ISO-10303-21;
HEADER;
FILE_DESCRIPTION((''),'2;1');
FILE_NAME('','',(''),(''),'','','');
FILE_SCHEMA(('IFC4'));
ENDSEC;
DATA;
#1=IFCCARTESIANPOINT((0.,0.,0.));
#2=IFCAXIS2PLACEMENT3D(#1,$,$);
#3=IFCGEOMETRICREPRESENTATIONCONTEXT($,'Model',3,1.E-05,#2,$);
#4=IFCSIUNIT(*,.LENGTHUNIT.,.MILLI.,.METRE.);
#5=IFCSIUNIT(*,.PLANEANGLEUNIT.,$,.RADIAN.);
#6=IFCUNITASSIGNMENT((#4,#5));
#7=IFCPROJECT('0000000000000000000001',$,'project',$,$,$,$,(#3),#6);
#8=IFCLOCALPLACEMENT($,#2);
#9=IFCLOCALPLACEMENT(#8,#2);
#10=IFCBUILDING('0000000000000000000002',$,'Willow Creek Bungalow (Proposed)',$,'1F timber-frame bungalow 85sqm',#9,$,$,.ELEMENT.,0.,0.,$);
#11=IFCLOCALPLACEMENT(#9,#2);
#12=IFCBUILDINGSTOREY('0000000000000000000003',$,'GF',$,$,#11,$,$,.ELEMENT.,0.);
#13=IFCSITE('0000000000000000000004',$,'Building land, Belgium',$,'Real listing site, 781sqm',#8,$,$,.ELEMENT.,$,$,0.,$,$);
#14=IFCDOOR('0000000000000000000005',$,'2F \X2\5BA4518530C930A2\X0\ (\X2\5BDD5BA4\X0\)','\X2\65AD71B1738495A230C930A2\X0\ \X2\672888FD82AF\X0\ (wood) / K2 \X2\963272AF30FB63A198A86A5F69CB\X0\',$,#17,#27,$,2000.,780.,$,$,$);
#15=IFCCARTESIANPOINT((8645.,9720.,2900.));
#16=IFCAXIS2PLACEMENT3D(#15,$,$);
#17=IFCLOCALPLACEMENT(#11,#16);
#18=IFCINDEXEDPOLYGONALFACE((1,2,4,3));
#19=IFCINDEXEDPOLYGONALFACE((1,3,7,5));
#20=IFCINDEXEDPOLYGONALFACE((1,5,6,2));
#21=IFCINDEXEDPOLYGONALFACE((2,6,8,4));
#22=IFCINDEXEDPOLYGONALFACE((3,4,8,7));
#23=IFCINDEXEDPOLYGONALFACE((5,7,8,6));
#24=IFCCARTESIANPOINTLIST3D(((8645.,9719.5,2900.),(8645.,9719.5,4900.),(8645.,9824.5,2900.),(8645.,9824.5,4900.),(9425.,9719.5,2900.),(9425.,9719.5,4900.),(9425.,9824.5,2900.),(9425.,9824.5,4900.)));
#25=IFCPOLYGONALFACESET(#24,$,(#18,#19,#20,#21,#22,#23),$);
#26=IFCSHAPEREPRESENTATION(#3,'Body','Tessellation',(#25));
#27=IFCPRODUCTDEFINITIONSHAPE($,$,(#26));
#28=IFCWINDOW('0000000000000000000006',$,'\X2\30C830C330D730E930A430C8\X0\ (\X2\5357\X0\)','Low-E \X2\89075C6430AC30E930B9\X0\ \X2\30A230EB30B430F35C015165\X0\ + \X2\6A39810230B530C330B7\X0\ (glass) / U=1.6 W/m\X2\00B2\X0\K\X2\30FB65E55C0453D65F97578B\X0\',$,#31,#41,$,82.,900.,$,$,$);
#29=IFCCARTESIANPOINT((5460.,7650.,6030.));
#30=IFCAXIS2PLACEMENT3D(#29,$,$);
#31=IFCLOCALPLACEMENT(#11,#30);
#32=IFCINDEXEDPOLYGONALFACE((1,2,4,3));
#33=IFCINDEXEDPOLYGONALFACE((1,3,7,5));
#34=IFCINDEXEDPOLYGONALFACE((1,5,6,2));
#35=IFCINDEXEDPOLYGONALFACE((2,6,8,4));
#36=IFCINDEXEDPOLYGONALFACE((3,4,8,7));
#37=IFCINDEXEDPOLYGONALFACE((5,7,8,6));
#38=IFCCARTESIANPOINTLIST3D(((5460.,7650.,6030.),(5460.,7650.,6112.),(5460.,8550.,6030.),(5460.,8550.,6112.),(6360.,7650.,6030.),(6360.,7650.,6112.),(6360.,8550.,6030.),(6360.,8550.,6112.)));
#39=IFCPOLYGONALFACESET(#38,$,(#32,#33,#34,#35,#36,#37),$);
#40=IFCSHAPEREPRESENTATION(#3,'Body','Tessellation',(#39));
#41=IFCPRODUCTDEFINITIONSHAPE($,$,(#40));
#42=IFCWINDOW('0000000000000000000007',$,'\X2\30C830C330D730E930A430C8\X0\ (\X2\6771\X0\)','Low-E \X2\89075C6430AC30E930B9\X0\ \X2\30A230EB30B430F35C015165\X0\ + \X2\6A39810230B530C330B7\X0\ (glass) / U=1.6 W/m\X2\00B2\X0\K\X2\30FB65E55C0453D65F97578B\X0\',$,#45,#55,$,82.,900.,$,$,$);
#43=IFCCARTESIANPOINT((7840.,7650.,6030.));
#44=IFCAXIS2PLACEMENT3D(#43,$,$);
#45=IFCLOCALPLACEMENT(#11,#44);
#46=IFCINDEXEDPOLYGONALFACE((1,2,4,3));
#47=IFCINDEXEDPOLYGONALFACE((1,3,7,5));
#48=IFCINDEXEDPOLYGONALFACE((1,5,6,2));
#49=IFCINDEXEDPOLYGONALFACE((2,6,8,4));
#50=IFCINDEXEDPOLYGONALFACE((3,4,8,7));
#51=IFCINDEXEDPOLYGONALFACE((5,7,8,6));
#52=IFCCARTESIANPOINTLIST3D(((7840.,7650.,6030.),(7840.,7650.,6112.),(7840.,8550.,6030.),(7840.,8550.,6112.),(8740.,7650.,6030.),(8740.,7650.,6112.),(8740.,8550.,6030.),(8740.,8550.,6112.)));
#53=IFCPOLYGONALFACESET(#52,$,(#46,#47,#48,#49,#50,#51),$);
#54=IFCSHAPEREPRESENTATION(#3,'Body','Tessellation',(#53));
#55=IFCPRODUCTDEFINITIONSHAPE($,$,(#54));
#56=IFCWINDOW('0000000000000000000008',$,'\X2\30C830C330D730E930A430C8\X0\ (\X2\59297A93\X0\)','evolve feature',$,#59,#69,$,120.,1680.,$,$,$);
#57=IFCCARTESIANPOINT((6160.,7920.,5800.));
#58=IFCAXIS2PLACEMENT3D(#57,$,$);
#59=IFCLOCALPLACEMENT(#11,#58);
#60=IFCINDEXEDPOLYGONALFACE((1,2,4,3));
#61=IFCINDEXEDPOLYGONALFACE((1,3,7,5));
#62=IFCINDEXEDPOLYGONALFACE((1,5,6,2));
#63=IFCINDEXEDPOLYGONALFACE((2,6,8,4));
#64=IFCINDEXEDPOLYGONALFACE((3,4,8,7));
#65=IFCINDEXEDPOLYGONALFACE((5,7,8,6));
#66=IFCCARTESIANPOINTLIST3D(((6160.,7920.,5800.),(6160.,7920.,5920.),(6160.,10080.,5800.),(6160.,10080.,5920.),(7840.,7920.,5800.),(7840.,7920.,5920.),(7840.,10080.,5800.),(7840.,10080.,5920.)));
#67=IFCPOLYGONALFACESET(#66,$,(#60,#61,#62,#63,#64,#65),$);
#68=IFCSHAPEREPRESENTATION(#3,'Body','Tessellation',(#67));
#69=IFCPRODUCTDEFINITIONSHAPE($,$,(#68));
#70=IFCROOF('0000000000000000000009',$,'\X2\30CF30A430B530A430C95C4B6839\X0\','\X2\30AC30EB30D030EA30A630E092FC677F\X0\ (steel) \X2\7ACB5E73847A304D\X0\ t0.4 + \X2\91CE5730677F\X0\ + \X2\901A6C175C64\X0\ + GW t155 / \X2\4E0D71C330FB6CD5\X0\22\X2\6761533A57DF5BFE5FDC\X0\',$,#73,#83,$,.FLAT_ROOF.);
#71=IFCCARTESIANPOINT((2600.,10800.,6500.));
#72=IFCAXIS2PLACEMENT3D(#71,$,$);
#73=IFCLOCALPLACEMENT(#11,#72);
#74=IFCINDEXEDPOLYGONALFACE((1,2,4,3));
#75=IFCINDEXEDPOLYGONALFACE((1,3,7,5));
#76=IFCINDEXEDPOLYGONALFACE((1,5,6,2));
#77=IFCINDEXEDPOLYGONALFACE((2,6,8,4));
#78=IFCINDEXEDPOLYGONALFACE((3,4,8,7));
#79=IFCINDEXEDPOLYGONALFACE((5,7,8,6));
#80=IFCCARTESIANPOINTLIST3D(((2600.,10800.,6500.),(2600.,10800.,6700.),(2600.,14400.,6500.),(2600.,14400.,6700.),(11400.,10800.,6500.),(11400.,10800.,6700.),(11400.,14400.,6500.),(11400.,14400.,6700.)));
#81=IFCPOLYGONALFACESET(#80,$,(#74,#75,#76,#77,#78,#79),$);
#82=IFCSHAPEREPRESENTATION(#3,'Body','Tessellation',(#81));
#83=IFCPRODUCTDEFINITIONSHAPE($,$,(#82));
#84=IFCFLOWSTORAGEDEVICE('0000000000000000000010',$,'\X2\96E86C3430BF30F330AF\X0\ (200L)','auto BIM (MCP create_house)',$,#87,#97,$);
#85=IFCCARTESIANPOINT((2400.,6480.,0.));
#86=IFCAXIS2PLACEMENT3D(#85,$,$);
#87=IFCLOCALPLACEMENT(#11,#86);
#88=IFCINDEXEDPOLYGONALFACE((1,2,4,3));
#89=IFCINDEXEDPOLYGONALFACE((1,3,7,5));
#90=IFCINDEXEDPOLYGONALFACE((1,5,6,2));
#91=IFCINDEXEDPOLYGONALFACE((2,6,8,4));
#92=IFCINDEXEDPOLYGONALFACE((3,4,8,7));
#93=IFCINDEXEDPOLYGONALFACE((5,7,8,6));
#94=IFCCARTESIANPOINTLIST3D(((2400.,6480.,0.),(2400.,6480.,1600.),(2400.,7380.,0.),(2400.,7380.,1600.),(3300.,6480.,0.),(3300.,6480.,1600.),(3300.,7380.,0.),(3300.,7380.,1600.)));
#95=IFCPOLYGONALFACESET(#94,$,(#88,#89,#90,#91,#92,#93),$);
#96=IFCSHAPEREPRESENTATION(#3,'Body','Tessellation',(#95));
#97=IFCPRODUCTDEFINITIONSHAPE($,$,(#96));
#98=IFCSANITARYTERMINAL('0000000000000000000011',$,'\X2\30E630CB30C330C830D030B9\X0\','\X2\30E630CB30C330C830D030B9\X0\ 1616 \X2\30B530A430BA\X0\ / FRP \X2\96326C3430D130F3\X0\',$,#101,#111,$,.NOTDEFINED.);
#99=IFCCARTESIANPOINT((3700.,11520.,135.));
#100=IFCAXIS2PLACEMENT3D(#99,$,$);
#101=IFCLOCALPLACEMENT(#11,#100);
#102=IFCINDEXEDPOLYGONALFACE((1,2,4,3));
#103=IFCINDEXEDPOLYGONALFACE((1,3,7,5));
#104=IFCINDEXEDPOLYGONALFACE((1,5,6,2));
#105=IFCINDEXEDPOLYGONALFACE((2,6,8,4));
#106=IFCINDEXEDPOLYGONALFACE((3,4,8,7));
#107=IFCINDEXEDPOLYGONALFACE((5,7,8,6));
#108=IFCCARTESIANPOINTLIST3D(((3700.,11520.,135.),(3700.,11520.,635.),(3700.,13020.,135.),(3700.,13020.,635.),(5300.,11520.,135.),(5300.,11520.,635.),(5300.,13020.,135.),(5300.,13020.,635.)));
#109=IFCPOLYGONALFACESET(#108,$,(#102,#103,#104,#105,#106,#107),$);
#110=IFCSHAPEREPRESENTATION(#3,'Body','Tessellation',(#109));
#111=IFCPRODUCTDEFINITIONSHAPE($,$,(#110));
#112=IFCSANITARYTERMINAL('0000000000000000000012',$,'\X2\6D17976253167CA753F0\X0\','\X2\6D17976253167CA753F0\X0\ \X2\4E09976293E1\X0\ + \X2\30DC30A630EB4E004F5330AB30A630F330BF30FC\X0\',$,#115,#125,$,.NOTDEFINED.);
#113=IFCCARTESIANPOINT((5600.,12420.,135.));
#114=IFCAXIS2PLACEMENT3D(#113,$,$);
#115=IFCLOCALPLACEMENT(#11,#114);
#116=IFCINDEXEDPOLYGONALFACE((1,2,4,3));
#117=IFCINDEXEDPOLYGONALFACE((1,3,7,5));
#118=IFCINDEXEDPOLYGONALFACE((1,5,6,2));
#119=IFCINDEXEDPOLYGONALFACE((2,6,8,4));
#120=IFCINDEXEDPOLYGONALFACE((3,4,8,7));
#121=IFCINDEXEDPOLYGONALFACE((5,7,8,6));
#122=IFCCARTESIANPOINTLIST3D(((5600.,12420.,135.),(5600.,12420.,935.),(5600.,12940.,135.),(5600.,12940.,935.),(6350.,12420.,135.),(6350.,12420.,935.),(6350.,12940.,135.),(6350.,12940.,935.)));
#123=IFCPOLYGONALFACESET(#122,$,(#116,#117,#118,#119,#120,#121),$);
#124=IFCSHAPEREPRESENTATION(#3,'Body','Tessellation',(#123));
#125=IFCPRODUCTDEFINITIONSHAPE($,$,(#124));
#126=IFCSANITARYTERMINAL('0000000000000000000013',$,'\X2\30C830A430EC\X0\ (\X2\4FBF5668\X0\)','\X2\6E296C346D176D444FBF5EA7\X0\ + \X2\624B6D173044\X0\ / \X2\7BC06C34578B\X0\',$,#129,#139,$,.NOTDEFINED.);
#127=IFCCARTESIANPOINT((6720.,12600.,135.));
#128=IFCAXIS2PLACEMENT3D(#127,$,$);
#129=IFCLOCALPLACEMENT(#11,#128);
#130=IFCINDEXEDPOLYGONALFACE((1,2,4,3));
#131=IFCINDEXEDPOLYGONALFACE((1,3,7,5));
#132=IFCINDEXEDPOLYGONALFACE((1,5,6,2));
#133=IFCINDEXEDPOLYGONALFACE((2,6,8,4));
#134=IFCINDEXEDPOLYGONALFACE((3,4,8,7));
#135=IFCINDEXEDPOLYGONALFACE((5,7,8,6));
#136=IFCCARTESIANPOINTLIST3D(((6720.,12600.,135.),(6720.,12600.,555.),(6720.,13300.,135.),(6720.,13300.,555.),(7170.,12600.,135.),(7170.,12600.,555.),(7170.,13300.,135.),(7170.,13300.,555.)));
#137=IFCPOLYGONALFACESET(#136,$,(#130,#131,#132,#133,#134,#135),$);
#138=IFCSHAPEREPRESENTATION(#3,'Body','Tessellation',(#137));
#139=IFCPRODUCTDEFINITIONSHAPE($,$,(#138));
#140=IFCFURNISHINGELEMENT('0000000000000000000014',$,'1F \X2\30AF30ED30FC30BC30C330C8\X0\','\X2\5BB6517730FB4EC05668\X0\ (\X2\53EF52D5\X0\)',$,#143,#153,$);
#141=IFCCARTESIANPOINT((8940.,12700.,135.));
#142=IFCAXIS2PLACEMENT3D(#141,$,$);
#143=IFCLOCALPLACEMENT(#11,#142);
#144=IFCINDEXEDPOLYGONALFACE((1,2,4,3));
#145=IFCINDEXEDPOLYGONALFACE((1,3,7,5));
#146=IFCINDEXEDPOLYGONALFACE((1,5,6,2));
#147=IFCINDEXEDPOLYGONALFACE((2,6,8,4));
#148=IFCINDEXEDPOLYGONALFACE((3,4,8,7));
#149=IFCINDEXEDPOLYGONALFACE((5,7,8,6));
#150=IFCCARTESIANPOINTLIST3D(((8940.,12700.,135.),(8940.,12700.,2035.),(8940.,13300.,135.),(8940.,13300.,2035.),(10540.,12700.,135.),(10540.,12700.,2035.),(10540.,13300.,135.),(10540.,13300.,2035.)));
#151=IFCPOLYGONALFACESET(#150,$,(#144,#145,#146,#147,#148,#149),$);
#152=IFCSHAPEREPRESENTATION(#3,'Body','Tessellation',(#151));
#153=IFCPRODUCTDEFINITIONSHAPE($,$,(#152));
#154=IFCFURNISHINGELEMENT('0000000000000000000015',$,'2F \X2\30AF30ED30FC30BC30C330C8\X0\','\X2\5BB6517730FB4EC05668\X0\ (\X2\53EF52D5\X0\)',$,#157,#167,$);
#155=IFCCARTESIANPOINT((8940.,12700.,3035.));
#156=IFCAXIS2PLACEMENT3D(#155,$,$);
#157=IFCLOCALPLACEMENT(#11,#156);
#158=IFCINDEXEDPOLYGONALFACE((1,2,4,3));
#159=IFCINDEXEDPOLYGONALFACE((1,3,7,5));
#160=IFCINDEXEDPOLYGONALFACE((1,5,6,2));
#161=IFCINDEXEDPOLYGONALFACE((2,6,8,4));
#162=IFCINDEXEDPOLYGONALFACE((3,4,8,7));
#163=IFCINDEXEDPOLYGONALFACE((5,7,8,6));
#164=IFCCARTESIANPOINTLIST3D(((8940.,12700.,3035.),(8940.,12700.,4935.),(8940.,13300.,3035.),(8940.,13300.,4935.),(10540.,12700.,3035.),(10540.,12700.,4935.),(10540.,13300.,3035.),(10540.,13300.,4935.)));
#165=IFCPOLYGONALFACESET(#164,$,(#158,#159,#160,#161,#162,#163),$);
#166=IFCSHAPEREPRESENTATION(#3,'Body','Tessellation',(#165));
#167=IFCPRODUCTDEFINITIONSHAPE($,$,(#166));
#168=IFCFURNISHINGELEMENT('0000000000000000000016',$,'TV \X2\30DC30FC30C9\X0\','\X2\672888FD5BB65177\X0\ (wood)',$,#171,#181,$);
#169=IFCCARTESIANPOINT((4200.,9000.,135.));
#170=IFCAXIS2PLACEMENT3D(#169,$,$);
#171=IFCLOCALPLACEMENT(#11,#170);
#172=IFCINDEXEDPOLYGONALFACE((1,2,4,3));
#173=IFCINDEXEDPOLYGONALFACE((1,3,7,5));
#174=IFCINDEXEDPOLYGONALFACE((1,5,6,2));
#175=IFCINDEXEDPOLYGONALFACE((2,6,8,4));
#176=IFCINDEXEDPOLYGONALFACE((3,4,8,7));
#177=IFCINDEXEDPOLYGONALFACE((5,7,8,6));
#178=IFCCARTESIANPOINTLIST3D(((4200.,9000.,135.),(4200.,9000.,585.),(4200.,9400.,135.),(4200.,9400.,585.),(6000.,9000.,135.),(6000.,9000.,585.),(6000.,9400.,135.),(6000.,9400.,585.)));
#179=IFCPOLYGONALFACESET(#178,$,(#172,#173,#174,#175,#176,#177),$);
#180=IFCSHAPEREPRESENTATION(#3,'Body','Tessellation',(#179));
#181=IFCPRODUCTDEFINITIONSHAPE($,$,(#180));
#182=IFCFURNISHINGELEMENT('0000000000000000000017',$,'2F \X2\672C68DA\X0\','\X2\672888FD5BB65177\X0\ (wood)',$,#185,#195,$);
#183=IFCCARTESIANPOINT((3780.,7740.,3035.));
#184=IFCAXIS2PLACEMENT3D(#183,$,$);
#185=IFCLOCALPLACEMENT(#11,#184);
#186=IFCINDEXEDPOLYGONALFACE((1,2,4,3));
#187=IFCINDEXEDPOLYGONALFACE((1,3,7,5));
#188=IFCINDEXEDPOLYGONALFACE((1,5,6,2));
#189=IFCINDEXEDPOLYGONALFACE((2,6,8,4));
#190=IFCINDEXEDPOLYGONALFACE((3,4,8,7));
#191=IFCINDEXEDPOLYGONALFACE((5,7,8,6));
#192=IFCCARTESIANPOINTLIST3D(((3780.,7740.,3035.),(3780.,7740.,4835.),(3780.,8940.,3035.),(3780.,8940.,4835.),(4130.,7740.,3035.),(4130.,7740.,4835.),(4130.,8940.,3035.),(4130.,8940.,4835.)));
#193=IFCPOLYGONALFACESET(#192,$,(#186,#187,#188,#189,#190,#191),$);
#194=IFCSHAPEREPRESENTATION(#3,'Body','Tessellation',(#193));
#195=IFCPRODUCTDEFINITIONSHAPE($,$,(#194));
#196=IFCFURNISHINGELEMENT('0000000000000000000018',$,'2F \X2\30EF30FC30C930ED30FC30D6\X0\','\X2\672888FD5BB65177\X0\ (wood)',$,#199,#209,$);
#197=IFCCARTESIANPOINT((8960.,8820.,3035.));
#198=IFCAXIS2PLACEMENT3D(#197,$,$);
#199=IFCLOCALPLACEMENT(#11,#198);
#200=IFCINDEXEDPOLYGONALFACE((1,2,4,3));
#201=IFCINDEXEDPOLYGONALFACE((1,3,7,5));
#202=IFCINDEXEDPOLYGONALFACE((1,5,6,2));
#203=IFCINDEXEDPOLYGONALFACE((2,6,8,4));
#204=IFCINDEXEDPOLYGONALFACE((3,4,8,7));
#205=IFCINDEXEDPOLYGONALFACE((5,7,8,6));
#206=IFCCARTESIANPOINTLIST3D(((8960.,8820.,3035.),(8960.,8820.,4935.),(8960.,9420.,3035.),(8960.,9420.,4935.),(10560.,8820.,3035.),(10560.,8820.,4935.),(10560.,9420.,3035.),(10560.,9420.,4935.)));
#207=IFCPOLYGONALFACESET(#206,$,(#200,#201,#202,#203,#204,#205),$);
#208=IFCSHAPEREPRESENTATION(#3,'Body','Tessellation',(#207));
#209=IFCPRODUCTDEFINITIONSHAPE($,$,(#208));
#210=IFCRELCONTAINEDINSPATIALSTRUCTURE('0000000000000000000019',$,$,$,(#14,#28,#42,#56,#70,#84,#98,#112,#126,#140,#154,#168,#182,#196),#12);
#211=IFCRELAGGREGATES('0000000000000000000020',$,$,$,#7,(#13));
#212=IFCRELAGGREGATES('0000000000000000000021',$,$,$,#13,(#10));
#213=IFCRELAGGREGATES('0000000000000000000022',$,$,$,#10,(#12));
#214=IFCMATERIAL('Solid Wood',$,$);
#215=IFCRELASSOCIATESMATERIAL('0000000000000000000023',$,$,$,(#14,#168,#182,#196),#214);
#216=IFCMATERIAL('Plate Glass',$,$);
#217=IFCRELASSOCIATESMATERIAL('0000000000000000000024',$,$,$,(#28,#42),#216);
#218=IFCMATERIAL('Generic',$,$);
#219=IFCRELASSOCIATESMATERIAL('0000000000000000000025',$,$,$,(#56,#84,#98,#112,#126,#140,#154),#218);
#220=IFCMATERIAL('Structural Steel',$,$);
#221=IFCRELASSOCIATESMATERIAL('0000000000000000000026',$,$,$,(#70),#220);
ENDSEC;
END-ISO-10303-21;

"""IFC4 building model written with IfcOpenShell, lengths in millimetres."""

from ifc_helpers import new_model, si_unit, frame, frame_2d, origin, place, context, project, spatial, rectangle, extrude, material, element, save


model = new_model("IFC4")

# Units and contexts
model_context = context("Model", 3, precision=1e-05, world=origin())
ifc_project = project(units=[si_unit("LENGTHUNIT", "METRE", prefix="MILLI"), si_unit("PLANEANGLEUNIT", "RADIAN")], contexts=[model_context])

# Site, building, storey
site_placement = place(None, origin())
site = spatial("IfcSite", under=ifc_project, at=site_placement, Name="Building land, Belgium", ObjectType="Real listing site, 781sqm", CompositionType="ELEMENT", RefElevation=0.0)
building_placement = place(site_placement, origin())
building = spatial("IfcBuilding", under=site, at=building_placement, Name="Willow Creek Bungalow (Proposed)", ObjectType="1F timber-frame bungalow 85sqm", CompositionType="ELEMENT", ElevationOfRefHeight=0.0, ElevationOfTerrain=0.0)
storey_placement = place(building_placement, origin())
storey = spatial("IfcBuildingStorey", under=building, at=storey_placement, Name="GF", CompositionType="ELEMENT", Elevation=0.0)

# Shared definitions
ifc_material_1 = material(Name="Solid Wood")
ifc_material_2 = material(Name="Plate Glass")

# Door
door_1_placement = place(storey_placement, frame((8645.0, 9720.0, 2900.0)))
element("IfcDoor", 1, at=door_1_placement, inside=storey, material=ifc_material_1, Name="2F 室内ドア (寝室)", Description="断熱玄関ドア 木製芯 (wood) / K2 防犯・採風機構", OverallHeight=2000.0, OverallWidth=780.0, context=model_context, shape_type="SweptSolid", body=[
    extrude(rectangle(XDim=780.0, YDim=105.0, at=frame_2d((390.0, 52.0))), frame((8645.0, 9720.0, 2900.0)), (0.0, 0.0, 1.0), 2000.0),
])

# Windows
window_1_placement = place(storey_placement, frame((5460.0, 7650.0, 6030.0)))
element("IfcWindow", 2, at=window_1_placement, inside=storey, material=ifc_material_2, Name="トップライト (南)", Description="Low-E 複層ガラス アルゴン封入 + 樹脂サッシ (glass) / U=1.6 W/m²K・日射取得型", OverallHeight=82.0, OverallWidth=900.0, context=model_context, shape_type="SweptSolid", body=[
    extrude(rectangle(XDim=900.0, YDim=900.0, at=frame_2d((450.0, 450.0))), frame((5460.0, 7650.0, 6030.0)), (0.0, 0.0, 1.0), 82.0),
])
window_2_placement = place(storey_placement, frame((7840.0, 7650.0, 6030.0)))
element("IfcWindow", 3, at=window_2_placement, inside=storey, material=ifc_material_2, Name="トップライト (東)", Description="Low-E 複層ガラス アルゴン封入 + 樹脂サッシ (glass) / U=1.6 W/m²K・日射取得型", OverallHeight=82.0, OverallWidth=900.0, context=model_context, shape_type="SweptSolid", body=[
    extrude(rectangle(XDim=900.0, YDim=900.0, at=frame_2d((450.0, 450.0))), frame((7840.0, 7650.0, 6030.0)), (0.0, 0.0, 1.0), 82.0),
])
ifc_material_3 = material(Name="Generic")
window_3_placement = place(storey_placement, frame((6160.0, 7920.0, 5800.0)))
element("IfcWindow", 4, at=window_3_placement, inside=storey, material=ifc_material_3, Name="トップライト (天窓)", Description="evolve feature", OverallHeight=120.0, OverallWidth=1680.0, context=model_context, shape_type="SweptSolid", body=[
    extrude(rectangle(XDim=1680.0, YDim=2160.0, at=frame_2d((840.0, 1080.0))), frame((6160.0, 7920.0, 5800.0)), (0.0, 0.0, 1.0), 120.0),
])

# Roof
ifc_material_4 = material(Name="Structural Steel")
roof_placement = place(storey_placement, frame((2600.0, 10800.0, 6500.0)))
element("IfcRoof", 5, at=roof_placement, inside=storey, material=ifc_material_4, Name="ハイサイド屋根", Description="ガルバリウム鋼板 (steel) 立平葺き t0.4 + 野地板 + 通気層 + GW t155 / 不燃・法22条区域対応", PredefinedType="FLAT_ROOF", context=model_context, shape_type="SweptSolid", body=[
    extrude(rectangle(XDim=8800.0, YDim=3600.0, at=frame_2d((4400.0, 1800.0))), frame((2600.0, 10800.0, 6500.0)), (0.0, 0.0, 1.0), 200.0),
])

# Flow storage device
flow_storage_device_placement = place(storey_placement, frame((2400.0, 6480.0, 0.0)))
element("IfcFlowStorageDevice", 6, at=flow_storage_device_placement, inside=storey, material=ifc_material_3, Name="雨水タンク (200L)", Description="auto BIM (MCP create_house)", context=model_context, shape_type="SweptSolid", body=[
    extrude(rectangle(XDim=900.0, YDim=900.0, at=frame_2d((450.0, 450.0))), frame((2400.0, 6480.0, 0.0)), (0.0, 0.0, 1.0), 1600.0),
])

# Sanitary terminals
sanitary_terminal_1_placement = place(storey_placement, frame((3700.0, 11520.0, 135.0)))
element("IfcSanitaryTerminal", 7, at=sanitary_terminal_1_placement, inside=storey, material=ifc_material_3, Name="ユニットバス", Description="ユニットバス 1616 サイズ / FRP 防水パン", PredefinedType="NOTDEFINED", context=model_context, shape_type="SweptSolid", body=[
    extrude(rectangle(XDim=1600.0, YDim=1500.0, at=frame_2d((800.0, 750.0))), frame((3700.0, 11520.0, 135.0)), (0.0, 0.0, 1.0), 500.0),
])
sanitary_terminal_2_placement = place(storey_placement, frame((5600.0, 12420.0, 135.0)))
element("IfcSanitaryTerminal", 8, at=sanitary_terminal_2_placement, inside=storey, material=ifc_material_3, Name="洗面化粧台", Description="洗面化粧台 三面鏡 + ボウル一体カウンター", PredefinedType="NOTDEFINED", context=model_context, shape_type="SweptSolid", body=[
    extrude(rectangle(XDim=750.0, YDim=520.0, at=frame_2d((375.0, 260.0))), frame((5600.0, 12420.0, 135.0)), (0.0, 0.0, 1.0), 800.0),
])
sanitary_terminal_3_placement = place(storey_placement, frame((6720.0, 12600.0, 135.0)))
element("IfcSanitaryTerminal", 9, at=sanitary_terminal_3_placement, inside=storey, material=ifc_material_3, Name="トイレ (便器)", Description="温水洗浄便座 + 手洗い / 節水型", PredefinedType="NOTDEFINED", context=model_context, shape_type="SweptSolid", body=[
    extrude(rectangle(XDim=450.0, YDim=700.0, at=frame_2d((225.0, 350.0))), frame((6720.0, 12600.0, 135.0)), (0.0, 0.0, 1.0), 420.0),
])

# Furnishing elements
furnishing_1_placement = place(storey_placement, frame((8940.0, 12700.0, 135.0)))
element("IfcFurnishingElement", 10, at=furnishing_1_placement, inside=storey, material=ifc_material_3, Name="1F クローゼット", Description="家具・什器 (可動)", context=model_context, shape_type="SweptSolid", body=[
    extrude(rectangle(XDim=1600.0, YDim=600.0, at=frame_2d((800.0, 300.0))), frame((8940.0, 12700.0, 135.0)), (0.0, 0.0, 1.0), 1900.0),
])
furnishing_2_placement = place(storey_placement, frame((8940.0, 12700.0, 3035.0)))
element("IfcFurnishingElement", 11, at=furnishing_2_placement, inside=storey, material=ifc_material_3, Name="2F クローゼット", Description="家具・什器 (可動)", context=model_context, shape_type="SweptSolid", body=[
    extrude(rectangle(XDim=1600.0, YDim=600.0, at=frame_2d((800.0, 300.0))), frame((8940.0, 12700.0, 3035.0)), (0.0, 0.0, 1.0), 1900.0),
])
furnishing_3_placement = place(storey_placement, frame((4200.0, 9000.0, 135.0)))
element("IfcFurnishingElement", 12, at=furnishing_3_placement, inside=storey, material=ifc_material_1, Name="TV ボード", Description="木製家具 (wood)", context=model_context, shape_type="SweptSolid", body=[
    extrude(rectangle(XDim=1800.0, YDim=400.0, at=frame_2d((900.0, 200.0))), frame((4200.0, 9000.0, 135.0)), (0.0, 0.0, 1.0), 450.0),
])
furnishing_4_placement = place(storey_placement, frame((3780.0, 7740.0, 3035.0)))
element("IfcFurnishingElement", 13, at=furnishing_4_placement, inside=storey, material=ifc_material_1, Name="2F 本棚", Description="木製家具 (wood)", context=model_context, shape_type="SweptSolid", body=[
    extrude(rectangle(XDim=350.0, YDim=1200.0, at=frame_2d((175.0, 600.0))), frame((3780.0, 7740.0, 3035.0)), (0.0, 0.0, 1.0), 1800.0),
])
furnishing_5_placement = place(storey_placement, frame((8960.0, 8820.0, 3035.0)))
element("IfcFurnishingElement", 14, at=furnishing_5_placement, inside=storey, material=ifc_material_1, Name="2F ワードローブ", Description="木製家具 (wood)", context=model_context, shape_type="SweptSolid", body=[
    extrude(rectangle(XDim=1600.0, YDim=600.0, at=frame_2d((800.0, 300.0))), frame((8960.0, 8820.0, 3035.0)), (0.0, 0.0, 1.0), 1900.0),
])

save(model, "model.ifc")
